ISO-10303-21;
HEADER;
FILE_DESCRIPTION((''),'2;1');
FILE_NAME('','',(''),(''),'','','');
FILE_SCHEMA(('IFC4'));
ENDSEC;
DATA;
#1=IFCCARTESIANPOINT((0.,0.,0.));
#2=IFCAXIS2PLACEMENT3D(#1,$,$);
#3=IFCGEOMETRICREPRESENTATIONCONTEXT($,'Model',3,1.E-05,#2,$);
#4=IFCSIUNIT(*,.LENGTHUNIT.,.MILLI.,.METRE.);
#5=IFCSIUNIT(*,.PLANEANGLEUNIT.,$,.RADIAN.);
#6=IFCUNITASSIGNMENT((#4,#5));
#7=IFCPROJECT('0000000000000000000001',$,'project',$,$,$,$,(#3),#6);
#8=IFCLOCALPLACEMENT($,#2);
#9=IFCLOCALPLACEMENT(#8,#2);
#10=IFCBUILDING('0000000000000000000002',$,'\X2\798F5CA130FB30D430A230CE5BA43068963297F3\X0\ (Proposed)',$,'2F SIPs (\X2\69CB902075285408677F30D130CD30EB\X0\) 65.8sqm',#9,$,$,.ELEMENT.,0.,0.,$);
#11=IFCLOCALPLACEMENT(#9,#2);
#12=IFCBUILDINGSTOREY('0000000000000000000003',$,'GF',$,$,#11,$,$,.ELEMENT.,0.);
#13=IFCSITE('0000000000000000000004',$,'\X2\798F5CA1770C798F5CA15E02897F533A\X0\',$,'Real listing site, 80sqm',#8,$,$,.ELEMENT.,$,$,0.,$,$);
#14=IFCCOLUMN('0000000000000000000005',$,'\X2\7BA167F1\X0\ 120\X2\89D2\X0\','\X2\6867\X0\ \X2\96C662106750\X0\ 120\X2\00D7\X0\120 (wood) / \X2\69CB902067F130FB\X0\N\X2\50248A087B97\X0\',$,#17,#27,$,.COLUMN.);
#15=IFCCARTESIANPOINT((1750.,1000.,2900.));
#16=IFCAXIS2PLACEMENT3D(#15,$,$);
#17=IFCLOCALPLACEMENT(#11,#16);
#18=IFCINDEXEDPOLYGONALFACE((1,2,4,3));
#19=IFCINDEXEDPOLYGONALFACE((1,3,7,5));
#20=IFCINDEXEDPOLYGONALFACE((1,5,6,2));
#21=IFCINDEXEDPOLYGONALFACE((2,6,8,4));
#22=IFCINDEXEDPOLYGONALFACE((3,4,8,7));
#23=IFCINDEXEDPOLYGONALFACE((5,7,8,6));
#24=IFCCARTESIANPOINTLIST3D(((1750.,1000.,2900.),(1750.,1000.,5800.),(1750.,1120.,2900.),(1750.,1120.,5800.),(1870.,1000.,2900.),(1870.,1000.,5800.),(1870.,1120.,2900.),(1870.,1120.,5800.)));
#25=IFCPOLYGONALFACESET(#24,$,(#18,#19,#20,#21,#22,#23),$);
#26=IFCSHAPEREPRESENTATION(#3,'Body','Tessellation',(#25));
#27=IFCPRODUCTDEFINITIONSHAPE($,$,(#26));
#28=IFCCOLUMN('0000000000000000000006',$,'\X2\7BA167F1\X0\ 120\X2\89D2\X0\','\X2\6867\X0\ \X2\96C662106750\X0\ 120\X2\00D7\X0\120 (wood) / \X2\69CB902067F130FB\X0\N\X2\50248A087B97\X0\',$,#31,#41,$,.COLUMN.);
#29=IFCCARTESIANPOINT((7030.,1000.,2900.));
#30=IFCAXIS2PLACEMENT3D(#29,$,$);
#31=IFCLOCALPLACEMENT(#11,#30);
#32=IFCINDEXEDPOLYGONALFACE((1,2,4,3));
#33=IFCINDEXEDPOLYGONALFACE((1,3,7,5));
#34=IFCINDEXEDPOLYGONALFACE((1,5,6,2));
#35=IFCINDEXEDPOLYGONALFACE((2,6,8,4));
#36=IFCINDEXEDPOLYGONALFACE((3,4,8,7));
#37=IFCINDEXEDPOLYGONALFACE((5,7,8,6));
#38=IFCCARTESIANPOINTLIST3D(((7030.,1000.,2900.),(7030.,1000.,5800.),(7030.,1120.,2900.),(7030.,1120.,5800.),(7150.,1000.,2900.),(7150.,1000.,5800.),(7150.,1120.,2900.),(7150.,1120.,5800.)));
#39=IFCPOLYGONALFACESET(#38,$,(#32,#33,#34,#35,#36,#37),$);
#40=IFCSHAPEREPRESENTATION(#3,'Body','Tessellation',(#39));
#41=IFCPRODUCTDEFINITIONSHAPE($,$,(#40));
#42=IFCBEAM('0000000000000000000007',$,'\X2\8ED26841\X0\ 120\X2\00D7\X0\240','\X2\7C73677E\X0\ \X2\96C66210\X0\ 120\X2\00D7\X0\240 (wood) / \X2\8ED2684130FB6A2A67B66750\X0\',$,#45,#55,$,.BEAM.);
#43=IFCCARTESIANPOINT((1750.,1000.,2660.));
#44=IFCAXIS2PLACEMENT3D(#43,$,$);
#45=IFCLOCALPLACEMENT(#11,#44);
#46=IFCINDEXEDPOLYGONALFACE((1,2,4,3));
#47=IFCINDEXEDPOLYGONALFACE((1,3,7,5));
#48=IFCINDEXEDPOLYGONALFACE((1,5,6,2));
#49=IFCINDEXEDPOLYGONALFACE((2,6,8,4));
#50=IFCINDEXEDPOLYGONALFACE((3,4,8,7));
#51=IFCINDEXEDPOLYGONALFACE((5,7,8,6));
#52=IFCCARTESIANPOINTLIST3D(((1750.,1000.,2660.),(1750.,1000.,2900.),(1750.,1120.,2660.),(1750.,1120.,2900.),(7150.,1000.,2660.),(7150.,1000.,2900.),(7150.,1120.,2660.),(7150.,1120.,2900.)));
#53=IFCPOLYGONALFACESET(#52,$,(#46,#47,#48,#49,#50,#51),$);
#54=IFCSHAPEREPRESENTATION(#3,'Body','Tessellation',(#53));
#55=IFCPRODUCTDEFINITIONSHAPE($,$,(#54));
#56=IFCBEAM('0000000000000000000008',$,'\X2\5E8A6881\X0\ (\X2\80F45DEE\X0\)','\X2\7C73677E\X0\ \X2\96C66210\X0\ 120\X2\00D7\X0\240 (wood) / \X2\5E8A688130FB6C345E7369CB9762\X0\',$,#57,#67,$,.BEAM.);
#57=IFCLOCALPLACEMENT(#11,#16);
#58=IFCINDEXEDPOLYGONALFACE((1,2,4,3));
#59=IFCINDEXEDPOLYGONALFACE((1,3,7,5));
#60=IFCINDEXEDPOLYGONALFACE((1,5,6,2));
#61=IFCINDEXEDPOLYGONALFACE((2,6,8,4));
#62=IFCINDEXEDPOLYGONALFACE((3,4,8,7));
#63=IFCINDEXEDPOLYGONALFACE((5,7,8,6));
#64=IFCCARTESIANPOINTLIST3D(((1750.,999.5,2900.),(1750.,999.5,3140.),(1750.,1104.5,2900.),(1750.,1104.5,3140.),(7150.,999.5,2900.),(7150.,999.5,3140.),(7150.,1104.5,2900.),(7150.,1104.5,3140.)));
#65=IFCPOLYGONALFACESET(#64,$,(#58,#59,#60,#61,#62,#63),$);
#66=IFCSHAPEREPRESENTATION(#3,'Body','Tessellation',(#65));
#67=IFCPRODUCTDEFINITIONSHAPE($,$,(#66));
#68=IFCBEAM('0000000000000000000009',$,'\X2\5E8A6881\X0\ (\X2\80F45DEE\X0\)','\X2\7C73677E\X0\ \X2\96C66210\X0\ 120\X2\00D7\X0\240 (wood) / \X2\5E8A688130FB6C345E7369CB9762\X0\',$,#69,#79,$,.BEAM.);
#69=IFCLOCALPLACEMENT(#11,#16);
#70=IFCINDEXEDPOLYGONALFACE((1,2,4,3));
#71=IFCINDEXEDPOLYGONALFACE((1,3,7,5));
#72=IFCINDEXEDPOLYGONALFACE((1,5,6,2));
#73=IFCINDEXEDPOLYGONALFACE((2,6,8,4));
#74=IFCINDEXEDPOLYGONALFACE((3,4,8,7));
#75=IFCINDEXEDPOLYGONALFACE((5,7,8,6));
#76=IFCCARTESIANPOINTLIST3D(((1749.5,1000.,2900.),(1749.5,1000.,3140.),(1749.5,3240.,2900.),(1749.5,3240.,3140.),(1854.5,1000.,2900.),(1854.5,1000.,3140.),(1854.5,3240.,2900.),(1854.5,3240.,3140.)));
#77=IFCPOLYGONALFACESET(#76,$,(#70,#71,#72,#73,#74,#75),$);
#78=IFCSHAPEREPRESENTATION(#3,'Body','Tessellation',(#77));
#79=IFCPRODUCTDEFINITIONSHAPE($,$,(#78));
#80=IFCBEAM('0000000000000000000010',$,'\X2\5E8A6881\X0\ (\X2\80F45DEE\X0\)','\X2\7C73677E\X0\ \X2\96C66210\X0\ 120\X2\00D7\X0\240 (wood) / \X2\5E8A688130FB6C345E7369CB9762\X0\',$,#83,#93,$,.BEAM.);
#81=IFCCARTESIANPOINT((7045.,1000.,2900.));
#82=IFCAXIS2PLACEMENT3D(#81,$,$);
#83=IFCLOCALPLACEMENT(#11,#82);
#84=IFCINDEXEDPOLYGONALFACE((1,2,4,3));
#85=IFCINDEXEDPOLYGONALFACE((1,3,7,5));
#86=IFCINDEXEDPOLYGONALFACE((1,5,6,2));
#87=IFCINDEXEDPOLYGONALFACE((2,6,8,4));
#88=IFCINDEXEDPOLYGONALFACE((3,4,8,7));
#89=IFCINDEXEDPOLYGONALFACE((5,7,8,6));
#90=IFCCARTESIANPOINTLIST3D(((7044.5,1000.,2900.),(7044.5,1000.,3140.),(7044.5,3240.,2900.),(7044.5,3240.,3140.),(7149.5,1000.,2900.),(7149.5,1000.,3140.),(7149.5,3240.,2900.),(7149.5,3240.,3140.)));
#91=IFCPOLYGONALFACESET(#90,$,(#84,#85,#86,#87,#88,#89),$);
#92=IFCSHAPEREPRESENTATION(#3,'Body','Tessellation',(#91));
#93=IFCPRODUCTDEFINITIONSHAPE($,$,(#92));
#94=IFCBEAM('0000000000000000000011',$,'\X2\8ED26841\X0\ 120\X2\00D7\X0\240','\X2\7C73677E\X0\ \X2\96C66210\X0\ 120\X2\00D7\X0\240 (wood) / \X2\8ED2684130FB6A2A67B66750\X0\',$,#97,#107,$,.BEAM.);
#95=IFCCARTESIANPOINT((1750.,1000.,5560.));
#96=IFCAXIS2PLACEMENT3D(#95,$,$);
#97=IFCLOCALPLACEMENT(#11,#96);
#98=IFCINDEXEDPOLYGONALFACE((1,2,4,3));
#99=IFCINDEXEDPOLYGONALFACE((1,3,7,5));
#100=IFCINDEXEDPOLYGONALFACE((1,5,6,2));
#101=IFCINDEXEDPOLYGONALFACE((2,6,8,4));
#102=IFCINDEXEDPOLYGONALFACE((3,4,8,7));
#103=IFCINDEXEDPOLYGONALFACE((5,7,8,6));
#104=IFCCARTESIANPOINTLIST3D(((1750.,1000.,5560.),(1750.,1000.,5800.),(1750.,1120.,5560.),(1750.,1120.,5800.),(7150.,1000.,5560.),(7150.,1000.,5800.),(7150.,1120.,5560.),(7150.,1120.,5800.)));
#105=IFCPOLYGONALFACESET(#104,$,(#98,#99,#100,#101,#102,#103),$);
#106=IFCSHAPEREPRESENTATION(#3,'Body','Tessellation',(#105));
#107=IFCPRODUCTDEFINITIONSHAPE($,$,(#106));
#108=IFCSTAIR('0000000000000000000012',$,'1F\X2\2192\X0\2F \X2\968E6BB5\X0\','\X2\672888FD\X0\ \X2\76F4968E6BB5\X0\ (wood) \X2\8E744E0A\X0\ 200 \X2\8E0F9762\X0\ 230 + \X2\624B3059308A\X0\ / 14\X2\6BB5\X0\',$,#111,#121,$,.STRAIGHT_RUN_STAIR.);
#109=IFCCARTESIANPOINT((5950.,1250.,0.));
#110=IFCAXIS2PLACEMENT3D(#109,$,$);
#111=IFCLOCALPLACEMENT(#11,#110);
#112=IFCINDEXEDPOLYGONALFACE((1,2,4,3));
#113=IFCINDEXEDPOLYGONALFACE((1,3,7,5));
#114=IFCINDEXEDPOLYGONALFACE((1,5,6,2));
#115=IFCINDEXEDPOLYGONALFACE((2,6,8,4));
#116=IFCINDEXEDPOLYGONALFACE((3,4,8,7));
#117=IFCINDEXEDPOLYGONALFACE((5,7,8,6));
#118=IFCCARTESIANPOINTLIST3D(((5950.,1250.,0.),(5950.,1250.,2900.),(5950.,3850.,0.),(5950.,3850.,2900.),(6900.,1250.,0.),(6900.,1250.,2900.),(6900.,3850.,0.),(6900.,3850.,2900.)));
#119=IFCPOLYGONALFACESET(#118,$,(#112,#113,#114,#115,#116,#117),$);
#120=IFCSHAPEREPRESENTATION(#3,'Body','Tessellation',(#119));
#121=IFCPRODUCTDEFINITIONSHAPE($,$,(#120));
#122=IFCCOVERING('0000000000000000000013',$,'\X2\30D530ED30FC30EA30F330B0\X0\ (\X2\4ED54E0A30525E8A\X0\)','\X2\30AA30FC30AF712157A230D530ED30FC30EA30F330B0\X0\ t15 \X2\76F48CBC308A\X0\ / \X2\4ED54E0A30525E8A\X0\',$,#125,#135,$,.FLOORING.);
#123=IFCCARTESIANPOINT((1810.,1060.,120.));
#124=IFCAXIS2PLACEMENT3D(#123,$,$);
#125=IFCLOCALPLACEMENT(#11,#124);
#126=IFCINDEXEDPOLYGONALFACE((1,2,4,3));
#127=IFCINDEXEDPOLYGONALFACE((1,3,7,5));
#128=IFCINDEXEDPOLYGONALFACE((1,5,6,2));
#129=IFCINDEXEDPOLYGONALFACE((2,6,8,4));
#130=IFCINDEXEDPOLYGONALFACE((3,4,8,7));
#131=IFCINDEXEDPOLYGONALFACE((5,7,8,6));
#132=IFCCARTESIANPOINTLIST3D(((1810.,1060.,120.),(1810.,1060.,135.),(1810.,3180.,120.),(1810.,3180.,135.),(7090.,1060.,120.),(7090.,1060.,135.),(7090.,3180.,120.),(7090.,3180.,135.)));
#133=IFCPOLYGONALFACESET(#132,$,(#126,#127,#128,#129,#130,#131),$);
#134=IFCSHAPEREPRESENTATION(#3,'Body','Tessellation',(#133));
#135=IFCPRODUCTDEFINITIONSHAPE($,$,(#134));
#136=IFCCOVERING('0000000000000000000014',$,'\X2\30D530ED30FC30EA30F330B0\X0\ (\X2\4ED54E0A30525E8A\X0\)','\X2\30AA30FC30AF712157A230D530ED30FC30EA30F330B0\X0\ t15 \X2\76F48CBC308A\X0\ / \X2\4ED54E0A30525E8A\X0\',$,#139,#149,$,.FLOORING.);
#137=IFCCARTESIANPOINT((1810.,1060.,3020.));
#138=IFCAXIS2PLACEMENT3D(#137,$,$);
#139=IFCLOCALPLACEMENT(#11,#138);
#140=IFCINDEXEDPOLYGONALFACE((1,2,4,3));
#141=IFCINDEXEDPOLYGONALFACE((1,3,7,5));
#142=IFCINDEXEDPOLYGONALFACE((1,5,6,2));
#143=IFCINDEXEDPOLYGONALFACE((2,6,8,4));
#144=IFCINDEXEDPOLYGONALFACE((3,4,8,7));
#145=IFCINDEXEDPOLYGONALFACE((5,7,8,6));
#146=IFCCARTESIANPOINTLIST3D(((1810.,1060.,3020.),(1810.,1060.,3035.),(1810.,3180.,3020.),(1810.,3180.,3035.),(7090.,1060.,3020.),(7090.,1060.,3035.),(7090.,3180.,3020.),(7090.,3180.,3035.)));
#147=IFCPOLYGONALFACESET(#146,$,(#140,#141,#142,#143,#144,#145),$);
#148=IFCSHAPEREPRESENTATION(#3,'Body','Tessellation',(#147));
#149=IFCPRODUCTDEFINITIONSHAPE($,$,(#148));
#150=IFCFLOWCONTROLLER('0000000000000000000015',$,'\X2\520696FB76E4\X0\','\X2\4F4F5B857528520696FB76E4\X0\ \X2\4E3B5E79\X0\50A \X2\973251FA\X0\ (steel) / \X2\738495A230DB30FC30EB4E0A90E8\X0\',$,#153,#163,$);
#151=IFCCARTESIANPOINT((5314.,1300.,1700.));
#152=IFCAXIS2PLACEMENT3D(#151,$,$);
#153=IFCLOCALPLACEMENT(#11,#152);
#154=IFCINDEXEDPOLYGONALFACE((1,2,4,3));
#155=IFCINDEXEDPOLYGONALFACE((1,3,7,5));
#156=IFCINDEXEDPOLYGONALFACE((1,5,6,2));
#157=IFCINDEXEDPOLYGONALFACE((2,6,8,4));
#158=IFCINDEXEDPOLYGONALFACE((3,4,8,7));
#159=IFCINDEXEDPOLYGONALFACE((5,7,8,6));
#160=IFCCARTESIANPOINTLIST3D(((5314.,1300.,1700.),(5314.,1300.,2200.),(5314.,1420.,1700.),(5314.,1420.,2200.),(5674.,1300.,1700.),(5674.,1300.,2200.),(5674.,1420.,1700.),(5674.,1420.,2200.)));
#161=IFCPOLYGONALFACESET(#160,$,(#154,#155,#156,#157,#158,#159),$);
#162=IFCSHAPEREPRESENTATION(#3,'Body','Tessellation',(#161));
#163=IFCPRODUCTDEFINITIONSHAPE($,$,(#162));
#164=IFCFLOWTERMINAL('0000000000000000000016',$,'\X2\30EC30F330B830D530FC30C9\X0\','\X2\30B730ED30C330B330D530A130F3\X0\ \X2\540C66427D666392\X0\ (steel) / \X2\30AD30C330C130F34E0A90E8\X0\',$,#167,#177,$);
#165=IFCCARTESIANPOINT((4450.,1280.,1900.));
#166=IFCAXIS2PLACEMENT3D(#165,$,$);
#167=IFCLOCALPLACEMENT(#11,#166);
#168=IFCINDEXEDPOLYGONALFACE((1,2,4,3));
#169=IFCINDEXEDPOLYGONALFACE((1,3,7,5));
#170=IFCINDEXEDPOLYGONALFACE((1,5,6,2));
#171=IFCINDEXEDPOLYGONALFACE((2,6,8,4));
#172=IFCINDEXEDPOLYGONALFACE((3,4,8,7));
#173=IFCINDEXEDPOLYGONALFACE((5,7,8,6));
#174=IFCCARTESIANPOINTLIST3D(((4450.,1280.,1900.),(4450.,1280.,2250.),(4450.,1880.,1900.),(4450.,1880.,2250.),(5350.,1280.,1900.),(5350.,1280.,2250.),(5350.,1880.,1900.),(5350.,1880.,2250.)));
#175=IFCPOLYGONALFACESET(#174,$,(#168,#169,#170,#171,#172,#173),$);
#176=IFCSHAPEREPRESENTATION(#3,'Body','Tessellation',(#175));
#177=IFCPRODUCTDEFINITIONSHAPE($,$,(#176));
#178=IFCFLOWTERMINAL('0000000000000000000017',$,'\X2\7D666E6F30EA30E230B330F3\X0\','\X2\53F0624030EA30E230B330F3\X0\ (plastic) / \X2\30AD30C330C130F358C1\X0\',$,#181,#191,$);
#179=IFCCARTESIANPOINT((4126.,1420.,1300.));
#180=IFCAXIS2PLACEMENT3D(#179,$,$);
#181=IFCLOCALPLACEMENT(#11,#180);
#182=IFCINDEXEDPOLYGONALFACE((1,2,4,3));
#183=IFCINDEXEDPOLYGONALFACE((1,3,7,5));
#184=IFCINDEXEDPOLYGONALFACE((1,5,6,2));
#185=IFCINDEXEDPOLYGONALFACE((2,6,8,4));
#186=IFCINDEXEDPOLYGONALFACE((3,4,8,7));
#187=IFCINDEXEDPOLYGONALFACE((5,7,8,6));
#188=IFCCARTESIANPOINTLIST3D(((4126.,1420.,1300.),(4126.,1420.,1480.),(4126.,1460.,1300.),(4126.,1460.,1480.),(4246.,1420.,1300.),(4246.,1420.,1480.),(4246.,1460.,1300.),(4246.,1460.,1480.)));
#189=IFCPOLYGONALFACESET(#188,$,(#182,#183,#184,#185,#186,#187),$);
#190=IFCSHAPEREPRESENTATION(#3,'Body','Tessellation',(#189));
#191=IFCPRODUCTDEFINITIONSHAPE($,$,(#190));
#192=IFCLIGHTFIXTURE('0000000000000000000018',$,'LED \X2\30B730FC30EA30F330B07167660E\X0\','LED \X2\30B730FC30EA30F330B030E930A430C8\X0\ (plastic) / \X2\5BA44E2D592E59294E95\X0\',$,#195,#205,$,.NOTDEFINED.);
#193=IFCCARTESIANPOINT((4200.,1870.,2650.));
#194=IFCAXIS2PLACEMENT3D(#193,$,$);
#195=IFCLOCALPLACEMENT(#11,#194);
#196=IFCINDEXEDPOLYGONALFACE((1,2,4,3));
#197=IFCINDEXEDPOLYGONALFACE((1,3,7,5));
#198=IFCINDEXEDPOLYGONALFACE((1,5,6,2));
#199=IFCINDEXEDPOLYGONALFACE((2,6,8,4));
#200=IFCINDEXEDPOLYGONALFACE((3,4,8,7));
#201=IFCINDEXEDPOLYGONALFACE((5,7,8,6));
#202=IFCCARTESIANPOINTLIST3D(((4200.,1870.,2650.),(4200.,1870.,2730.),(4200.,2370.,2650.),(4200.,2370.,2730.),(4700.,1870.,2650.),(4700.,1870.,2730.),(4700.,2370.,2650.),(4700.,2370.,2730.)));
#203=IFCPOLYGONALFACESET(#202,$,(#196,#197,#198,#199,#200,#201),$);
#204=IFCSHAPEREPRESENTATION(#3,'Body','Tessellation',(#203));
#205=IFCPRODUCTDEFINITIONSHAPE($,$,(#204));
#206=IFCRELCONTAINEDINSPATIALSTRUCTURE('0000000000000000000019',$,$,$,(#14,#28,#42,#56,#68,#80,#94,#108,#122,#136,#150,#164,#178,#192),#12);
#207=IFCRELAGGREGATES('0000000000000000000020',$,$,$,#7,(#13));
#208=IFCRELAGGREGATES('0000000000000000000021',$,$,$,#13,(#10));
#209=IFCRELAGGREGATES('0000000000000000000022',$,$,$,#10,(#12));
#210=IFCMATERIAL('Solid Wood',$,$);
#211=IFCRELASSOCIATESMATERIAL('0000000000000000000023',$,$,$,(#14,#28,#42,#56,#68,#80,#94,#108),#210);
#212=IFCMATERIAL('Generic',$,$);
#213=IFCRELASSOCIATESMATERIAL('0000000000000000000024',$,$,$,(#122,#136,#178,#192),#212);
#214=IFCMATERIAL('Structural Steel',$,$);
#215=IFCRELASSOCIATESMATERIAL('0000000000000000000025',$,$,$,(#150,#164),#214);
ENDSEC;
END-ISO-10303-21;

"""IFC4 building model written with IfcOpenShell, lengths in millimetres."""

from ifc_helpers import new_model, si_unit, frame, frame_2d, origin, place, context, project, spatial, rectangle, extrude, material, element, save


model = new_model("IFC4")

# Units and contexts
model_context = context("Model", 3, precision=1e-05, world=origin())
ifc_project = project(units=[si_unit("LENGTHUNIT", "METRE", prefix="MILLI"), si_unit("PLANEANGLEUNIT", "RADIAN")], contexts=[model_context])

# Site, building, storey
site_placement = place(None, origin())
site = spatial("IfcSite", under=ifc_project, at=site_placement, Name="福岡県福岡市西区", ObjectType="Real listing site, 80sqm", CompositionType="ELEMENT", RefElevation=0.0)
building_placement = place(site_placement, origin())
building = spatial("IfcBuilding", under=site, at=building_placement, Name="福岡・ピアノ室と防音 (Proposed)", ObjectType="2F SIPs (構造用合板パネル) 65.8sqm", CompositionType="ELEMENT", ElevationOfRefHeight=0.0, ElevationOfTerrain=0.0)
storey_placement = place(building_placement, origin())
storey = spatial("IfcBuildingStorey", under=building, at=storey_placement, Name="GF", CompositionType="ELEMENT", Elevation=0.0)

# Columns
ifc_material_1 = material(Name="Solid Wood")
column_1_placement = place(storey_placement, frame((1750.0, 1000.0, 2900.0)))
element("IfcColumn", 1, at=column_1_placement, inside=storey, material=ifc_material_1, Name="管柱 120角", Description="桧 集成材 120×120 (wood) / 構造柱・N値計算", PredefinedType="COLUMN", context=model_context, shape_type="SweptSolid", body=[
    extrude(rectangle(XDim=120.0, YDim=120.0, at=frame_2d((60.0, 60.0))), frame((1750.0, 1000.0, 2900.0)), (0.0, 0.0, 1.0), 2900.0),
])
column_2_placement = place(storey_placement, frame((7030.0, 1000.0, 2900.0)))
element("IfcColumn", 2, at=column_2_placement, inside=storey, material=ifc_material_1, Name="管柱 120角", Description="桧 集成材 120×120 (wood) / 構造柱・N値計算", PredefinedType="COLUMN", context=model_context, shape_type="SweptSolid", body=[
    extrude(rectangle(XDim=120.0, YDim=120.0, at=frame_2d((60.0, 60.0))), frame((7030.0, 1000.0, 2900.0)), (0.0, 0.0, 1.0), 2900.0),
])

# Beams
beam_1_placement = place(storey_placement, frame((1750.0, 1000.0, 2660.0)))
element("IfcBeam", 3, at=beam_1_placement, inside=storey, material=ifc_material_1, Name="軒桁 120×240", Description="米松 集成 120×240 (wood) / 軒桁・横架材", PredefinedType="BEAM", context=model_context, shape_type="SweptSolid", body=[
    extrude(rectangle(XDim=5400.0, YDim=120.0, at=frame_2d((2700.0, 60.0))), frame((1750.0, 1000.0, 2660.0)), (0.0, 0.0, 1.0), 240.0),
])
beam_2_placement = place(storey_placement, frame((1750.0, 1000.0, 2900.0)))
element("IfcBeam", 4, at=beam_2_placement, inside=storey, material=ifc_material_1, Name="床梁 (胴差)", Description="米松 集成 120×240 (wood) / 床梁・水平構面", PredefinedType="BEAM", context=model_context, shape_type="SweptSolid", body=[
    extrude(rectangle(XDim=5400.0, YDim=105.0, at=frame_2d((2700.0, 52.0))), frame((1750.0, 1000.0, 2900.0)), (0.0, 0.0, 1.0), 240.0),
])
beam_3_placement = place(storey_placement, frame((1750.0, 1000.0, 2900.0)))
element("IfcBeam", 5, at=beam_3_placement, inside=storey, material=ifc_material_1, Name="床梁 (胴差)", Description="米松 集成 120×240 (wood) / 床梁・水平構面", PredefinedType="BEAM", context=model_context, shape_type="SweptSolid", body=[
    extrude(rectangle(XDim=105.0, YDim=2240.0, at=frame_2d((52.0, 1120.0))), frame((1750.0, 1000.0, 2900.0)), (0.0, 0.0, 1.0), 240.0),
])
beam_4_placement = place(storey_placement, frame((7045.0, 1000.0, 2900.0)))
element("IfcBeam", 6, at=beam_4_placement, inside=storey, material=ifc_material_1, Name="床梁 (胴差)", Description="米松 集成 120×240 (wood) / 床梁・水平構面", PredefinedType="BEAM", context=model_context, shape_type="SweptSolid", body=[
    extrude(rectangle(XDim=105.0, YDim=2240.0, at=frame_2d((52.0, 1120.0))), frame((7045.0, 1000.0, 2900.0)), (0.0, 0.0, 1.0), 240.0),
])
beam_5_placement = place(storey_placement, frame((1750.0, 1000.0, 5560.0)))
element("IfcBeam", 7, at=beam_5_placement, inside=storey, material=ifc_material_1, Name="軒桁 120×240", Description="米松 集成 120×240 (wood) / 軒桁・横架材", PredefinedType="BEAM", context=model_context, shape_type="SweptSolid", body=[
    extrude(rectangle(XDim=5400.0, YDim=120.0, at=frame_2d((2700.0, 60.0))), frame((1750.0, 1000.0, 5560.0)), (0.0, 0.0, 1.0), 240.0),
])

# Stair
stair_placement = place(storey_placement, frame((5950.0, 1250.0, 0.0)))
element("IfcStair", 8, at=stair_placement, inside=storey, material=ifc_material_1, Name="1F→2F 階段", Description="木製 直階段 (wood) 蹴上 200 踏面 230 + 手すり / 14段", PredefinedType="STRAIGHT_RUN_STAIR", context=model_context, shape_type="SweptSolid", body=[
    extrude(rectangle(XDim=950.0, YDim=2600.0, at=frame_2d((475.0, 1300.0))), frame((5950.0, 1250.0, 0.0)), (0.0, 0.0, 1.0), 2900.0),
])

# Coverings
ifc_material_2 = material(Name="Generic")
covering_1_placement = place(storey_placement, frame((1810.0, 1060.0, 120.0)))
element("IfcCovering", 9, at=covering_1_placement, inside=storey, material=ifc_material_2, Name="フローリング (仕上げ床)", Description="オーク無垢フローリング t15 直貼り / 仕上げ床", PredefinedType="FLOORING", context=model_context, shape_type="SweptSolid", body=[
    extrude(rectangle(XDim=5280.0, YDim=2120.0, at=frame_2d((2640.0, 1060.0))), frame((1810.0, 1060.0, 120.0)), (0.0, 0.0, 1.0), 15.0),
])
covering_2_placement = place(storey_placement, frame((1810.0, 1060.0, 3020.0)))
element("IfcCovering", 10, at=covering_2_placement, inside=storey, material=ifc_material_2, Name="フローリング (仕上げ床)", Description="オーク無垢フローリング t15 直貼り / 仕上げ床", PredefinedType="FLOORING", context=model_context, shape_type="SweptSolid", body=[
    extrude(rectangle(XDim=5280.0, YDim=2120.0, at=frame_2d((2640.0, 1060.0))), frame((1810.0, 1060.0, 3020.0)), (0.0, 0.0, 1.0), 15.0),
])

# Flow controller
ifc_material_3 = material(Name="Structural Steel")
flow_controller_placement = place(storey_placement, frame((5314.0, 1300.0, 1700.0)))
element("IfcFlowController", 11, at=flow_controller_placement, inside=storey, material=ifc_material_3, Name="分電盤", Description="住宅用分電盤 主幹50A 露出 (steel) / 玄関ホール上部", context=model_context, shape_type="SweptSolid", body=[
    extrude(rectangle(XDim=360.0, YDim=120.0, at=frame_2d((180.0, 60.0))), frame((5314.0, 1300.0, 1700.0)), (0.0, 0.0, 1.0), 500.0),
])

# Flow terminals
flow_terminal_1_placement = place(storey_placement, frame((4450.0, 1280.0, 1900.0)))
element("IfcFlowTerminal", 12, at=flow_terminal_1_placement, inside=storey, material=ifc_material_3, Name="レンジフード", Description="シロッコファン 同時給排 (steel) / キッチン上部", context=model_context, shape_type="SweptSolid", body=[
    extrude(rectangle(XDim=900.0, YDim=600.0, at=frame_2d((450.0, 300.0))), frame((4450.0, 1280.0, 1900.0)), (0.0, 0.0, 1.0), 350.0),
])
flow_terminal_2_placement = place(storey_placement, frame((4126.0, 1420.0, 1300.0)))
element("IfcFlowTerminal", 13, at=flow_terminal_2_placement, inside=storey, material=ifc_material_2, Name="給湯リモコン", Description="台所リモコン (plastic) / キッチン壁", context=model_context, shape_type="SweptSolid", body=[
    extrude(rectangle(XDim=120.0, YDim=40.0, at=frame_2d((60.0, 20.0))), frame((4126.0, 1420.0, 1300.0)), (0.0, 0.0, 1.0), 180.0),
])

# Light fixture
light_fixture_1_placement = place(storey_placement, frame((4200.0, 1870.0, 2650.0)))
element("IfcLightFixture", 14, at=light_fixture_1_placement, inside=storey, material=ifc_material_2, Name="LED シーリング照明", Description="LED シーリングライト (plastic) / 室中央天井", PredefinedType="NOTDEFINED", context=model_context, shape_type="SweptSolid", body=[
    extrude(rectangle(XDim=500.0, YDim=500.0, at=frame_2d((250.0, 250.0))), frame((4200.0, 1870.0, 2650.0)), (0.0, 0.0, 1.0), 80.0),
])

save(model, "model.ifc")
